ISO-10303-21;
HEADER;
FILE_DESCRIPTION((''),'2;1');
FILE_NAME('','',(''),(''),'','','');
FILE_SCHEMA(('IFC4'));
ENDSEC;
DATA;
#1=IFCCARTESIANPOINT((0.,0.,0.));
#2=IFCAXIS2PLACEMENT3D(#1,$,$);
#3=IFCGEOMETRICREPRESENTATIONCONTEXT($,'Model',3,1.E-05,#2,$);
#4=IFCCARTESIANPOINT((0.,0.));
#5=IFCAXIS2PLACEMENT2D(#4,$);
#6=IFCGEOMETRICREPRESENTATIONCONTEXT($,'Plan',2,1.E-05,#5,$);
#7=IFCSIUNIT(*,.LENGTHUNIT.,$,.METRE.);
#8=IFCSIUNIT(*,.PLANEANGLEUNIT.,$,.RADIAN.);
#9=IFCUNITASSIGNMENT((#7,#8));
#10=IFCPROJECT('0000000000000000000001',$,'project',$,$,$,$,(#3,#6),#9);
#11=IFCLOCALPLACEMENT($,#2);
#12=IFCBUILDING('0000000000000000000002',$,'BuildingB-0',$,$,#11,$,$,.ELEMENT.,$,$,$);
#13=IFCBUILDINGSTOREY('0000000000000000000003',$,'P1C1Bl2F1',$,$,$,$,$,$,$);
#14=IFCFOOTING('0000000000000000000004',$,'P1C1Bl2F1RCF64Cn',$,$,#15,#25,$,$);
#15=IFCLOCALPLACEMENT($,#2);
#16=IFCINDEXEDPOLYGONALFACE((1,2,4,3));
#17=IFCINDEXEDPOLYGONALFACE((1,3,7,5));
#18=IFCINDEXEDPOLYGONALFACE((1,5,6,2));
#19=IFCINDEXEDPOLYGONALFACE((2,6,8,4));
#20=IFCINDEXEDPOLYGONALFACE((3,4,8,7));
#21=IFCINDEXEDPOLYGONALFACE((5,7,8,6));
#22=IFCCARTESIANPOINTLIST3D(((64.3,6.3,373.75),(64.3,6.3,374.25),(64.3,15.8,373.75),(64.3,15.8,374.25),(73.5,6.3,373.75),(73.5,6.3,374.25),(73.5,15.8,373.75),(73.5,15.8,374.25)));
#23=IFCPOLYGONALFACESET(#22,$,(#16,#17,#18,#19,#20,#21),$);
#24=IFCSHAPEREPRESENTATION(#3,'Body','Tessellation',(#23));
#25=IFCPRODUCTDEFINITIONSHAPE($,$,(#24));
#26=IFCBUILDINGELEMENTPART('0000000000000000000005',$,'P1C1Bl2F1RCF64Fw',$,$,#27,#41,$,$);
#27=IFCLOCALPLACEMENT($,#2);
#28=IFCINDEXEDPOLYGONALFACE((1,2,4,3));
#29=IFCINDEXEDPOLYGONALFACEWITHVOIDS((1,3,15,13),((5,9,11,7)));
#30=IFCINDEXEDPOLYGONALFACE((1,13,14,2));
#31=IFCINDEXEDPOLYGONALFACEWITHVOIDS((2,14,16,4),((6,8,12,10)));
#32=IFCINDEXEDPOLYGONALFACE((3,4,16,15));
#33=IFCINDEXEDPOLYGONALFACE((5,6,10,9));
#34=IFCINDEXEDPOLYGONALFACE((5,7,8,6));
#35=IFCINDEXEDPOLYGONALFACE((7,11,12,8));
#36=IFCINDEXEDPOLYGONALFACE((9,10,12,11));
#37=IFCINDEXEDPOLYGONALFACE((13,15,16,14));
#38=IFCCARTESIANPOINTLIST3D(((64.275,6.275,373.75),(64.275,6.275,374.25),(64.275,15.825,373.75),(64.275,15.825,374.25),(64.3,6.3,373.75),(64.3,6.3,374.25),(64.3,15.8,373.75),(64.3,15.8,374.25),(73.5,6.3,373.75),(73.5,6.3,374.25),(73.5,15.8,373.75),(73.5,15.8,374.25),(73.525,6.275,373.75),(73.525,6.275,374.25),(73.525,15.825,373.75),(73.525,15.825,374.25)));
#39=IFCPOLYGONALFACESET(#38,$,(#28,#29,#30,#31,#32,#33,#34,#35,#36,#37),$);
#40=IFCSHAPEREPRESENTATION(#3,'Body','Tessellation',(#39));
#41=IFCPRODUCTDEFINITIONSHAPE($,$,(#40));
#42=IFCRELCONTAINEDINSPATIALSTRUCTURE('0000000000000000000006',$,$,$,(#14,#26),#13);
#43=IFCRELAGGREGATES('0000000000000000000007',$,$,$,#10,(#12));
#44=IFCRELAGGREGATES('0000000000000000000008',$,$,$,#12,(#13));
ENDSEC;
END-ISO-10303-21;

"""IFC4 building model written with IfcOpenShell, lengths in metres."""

from ifc_helpers import new_model, si_unit, origin, origin_2d, place, context, project, spatial, polyline, outline, extrude, element, save


model = new_model("IFC4")

# Units and contexts
model_context = context("Model", 3, precision=1e-05, world=origin())
plan_context = context("Plan", 2, precision=1e-05, world=origin_2d())
ifc_project = project(units=[si_unit("LENGTHUNIT", "METRE"), si_unit("PLANEANGLEUNIT", "RADIAN")], contexts=[model_context, plan_context])

# Building, storey
building_placement = place(None, origin())
building = spatial("IfcBuilding", under=ifc_project, at=building_placement, Name="BuildingB-0", CompositionType="ELEMENT")
storey = spatial("IfcBuildingStorey", under=building, Name="P1C1Bl2F1")

# Footing
element("IfcFooting", 1, inside=storey, Name="P1C1Bl2F1RCF64Cn", context=model_context, shape_type="SweptSolid", body=[
    extrude(outline(polyline([(64.3, 15.8, 373.75), (73.5, 15.8, 373.75), (73.5, 6.3, 373.75), (64.3, 6.3, 373.75), (64.3, 15.8, 373.75)])), None, (0.0, 0.0, 1.0), 0.5),
])

# Building element part, opening
building_element_part = element("IfcBuildingElementPart", 2, inside=storey, Name="P1C1Bl2F1RCF64Fw", context=model_context, shape_type="SweptSolid", body=[
    extrude(outline(polyline([(64.275, 15.825, 373.75), (73.525, 15.825, 373.75), (73.525, 6.275, 373.75), (64.275, 6.275, 373.75), (64.275, 15.825, 373.75)])), None, (0.0, 0.0, 1.0), 0.5),
])
element("IfcOpeningElement", 3, inside=storey, cuts=building_element_part, context=model_context, shape_type="SweptSolid", body=[
    extrude(outline(polyline([(64.3, 15.8, 373.75), (73.5, 15.8, 373.75), (73.5, 6.3, 373.75), (64.3, 6.3, 373.75), (64.3, 15.8, 373.75)])), None, (0.0, 0.0, 1.0), 0.5),
])

save(model, "model.ifc")
